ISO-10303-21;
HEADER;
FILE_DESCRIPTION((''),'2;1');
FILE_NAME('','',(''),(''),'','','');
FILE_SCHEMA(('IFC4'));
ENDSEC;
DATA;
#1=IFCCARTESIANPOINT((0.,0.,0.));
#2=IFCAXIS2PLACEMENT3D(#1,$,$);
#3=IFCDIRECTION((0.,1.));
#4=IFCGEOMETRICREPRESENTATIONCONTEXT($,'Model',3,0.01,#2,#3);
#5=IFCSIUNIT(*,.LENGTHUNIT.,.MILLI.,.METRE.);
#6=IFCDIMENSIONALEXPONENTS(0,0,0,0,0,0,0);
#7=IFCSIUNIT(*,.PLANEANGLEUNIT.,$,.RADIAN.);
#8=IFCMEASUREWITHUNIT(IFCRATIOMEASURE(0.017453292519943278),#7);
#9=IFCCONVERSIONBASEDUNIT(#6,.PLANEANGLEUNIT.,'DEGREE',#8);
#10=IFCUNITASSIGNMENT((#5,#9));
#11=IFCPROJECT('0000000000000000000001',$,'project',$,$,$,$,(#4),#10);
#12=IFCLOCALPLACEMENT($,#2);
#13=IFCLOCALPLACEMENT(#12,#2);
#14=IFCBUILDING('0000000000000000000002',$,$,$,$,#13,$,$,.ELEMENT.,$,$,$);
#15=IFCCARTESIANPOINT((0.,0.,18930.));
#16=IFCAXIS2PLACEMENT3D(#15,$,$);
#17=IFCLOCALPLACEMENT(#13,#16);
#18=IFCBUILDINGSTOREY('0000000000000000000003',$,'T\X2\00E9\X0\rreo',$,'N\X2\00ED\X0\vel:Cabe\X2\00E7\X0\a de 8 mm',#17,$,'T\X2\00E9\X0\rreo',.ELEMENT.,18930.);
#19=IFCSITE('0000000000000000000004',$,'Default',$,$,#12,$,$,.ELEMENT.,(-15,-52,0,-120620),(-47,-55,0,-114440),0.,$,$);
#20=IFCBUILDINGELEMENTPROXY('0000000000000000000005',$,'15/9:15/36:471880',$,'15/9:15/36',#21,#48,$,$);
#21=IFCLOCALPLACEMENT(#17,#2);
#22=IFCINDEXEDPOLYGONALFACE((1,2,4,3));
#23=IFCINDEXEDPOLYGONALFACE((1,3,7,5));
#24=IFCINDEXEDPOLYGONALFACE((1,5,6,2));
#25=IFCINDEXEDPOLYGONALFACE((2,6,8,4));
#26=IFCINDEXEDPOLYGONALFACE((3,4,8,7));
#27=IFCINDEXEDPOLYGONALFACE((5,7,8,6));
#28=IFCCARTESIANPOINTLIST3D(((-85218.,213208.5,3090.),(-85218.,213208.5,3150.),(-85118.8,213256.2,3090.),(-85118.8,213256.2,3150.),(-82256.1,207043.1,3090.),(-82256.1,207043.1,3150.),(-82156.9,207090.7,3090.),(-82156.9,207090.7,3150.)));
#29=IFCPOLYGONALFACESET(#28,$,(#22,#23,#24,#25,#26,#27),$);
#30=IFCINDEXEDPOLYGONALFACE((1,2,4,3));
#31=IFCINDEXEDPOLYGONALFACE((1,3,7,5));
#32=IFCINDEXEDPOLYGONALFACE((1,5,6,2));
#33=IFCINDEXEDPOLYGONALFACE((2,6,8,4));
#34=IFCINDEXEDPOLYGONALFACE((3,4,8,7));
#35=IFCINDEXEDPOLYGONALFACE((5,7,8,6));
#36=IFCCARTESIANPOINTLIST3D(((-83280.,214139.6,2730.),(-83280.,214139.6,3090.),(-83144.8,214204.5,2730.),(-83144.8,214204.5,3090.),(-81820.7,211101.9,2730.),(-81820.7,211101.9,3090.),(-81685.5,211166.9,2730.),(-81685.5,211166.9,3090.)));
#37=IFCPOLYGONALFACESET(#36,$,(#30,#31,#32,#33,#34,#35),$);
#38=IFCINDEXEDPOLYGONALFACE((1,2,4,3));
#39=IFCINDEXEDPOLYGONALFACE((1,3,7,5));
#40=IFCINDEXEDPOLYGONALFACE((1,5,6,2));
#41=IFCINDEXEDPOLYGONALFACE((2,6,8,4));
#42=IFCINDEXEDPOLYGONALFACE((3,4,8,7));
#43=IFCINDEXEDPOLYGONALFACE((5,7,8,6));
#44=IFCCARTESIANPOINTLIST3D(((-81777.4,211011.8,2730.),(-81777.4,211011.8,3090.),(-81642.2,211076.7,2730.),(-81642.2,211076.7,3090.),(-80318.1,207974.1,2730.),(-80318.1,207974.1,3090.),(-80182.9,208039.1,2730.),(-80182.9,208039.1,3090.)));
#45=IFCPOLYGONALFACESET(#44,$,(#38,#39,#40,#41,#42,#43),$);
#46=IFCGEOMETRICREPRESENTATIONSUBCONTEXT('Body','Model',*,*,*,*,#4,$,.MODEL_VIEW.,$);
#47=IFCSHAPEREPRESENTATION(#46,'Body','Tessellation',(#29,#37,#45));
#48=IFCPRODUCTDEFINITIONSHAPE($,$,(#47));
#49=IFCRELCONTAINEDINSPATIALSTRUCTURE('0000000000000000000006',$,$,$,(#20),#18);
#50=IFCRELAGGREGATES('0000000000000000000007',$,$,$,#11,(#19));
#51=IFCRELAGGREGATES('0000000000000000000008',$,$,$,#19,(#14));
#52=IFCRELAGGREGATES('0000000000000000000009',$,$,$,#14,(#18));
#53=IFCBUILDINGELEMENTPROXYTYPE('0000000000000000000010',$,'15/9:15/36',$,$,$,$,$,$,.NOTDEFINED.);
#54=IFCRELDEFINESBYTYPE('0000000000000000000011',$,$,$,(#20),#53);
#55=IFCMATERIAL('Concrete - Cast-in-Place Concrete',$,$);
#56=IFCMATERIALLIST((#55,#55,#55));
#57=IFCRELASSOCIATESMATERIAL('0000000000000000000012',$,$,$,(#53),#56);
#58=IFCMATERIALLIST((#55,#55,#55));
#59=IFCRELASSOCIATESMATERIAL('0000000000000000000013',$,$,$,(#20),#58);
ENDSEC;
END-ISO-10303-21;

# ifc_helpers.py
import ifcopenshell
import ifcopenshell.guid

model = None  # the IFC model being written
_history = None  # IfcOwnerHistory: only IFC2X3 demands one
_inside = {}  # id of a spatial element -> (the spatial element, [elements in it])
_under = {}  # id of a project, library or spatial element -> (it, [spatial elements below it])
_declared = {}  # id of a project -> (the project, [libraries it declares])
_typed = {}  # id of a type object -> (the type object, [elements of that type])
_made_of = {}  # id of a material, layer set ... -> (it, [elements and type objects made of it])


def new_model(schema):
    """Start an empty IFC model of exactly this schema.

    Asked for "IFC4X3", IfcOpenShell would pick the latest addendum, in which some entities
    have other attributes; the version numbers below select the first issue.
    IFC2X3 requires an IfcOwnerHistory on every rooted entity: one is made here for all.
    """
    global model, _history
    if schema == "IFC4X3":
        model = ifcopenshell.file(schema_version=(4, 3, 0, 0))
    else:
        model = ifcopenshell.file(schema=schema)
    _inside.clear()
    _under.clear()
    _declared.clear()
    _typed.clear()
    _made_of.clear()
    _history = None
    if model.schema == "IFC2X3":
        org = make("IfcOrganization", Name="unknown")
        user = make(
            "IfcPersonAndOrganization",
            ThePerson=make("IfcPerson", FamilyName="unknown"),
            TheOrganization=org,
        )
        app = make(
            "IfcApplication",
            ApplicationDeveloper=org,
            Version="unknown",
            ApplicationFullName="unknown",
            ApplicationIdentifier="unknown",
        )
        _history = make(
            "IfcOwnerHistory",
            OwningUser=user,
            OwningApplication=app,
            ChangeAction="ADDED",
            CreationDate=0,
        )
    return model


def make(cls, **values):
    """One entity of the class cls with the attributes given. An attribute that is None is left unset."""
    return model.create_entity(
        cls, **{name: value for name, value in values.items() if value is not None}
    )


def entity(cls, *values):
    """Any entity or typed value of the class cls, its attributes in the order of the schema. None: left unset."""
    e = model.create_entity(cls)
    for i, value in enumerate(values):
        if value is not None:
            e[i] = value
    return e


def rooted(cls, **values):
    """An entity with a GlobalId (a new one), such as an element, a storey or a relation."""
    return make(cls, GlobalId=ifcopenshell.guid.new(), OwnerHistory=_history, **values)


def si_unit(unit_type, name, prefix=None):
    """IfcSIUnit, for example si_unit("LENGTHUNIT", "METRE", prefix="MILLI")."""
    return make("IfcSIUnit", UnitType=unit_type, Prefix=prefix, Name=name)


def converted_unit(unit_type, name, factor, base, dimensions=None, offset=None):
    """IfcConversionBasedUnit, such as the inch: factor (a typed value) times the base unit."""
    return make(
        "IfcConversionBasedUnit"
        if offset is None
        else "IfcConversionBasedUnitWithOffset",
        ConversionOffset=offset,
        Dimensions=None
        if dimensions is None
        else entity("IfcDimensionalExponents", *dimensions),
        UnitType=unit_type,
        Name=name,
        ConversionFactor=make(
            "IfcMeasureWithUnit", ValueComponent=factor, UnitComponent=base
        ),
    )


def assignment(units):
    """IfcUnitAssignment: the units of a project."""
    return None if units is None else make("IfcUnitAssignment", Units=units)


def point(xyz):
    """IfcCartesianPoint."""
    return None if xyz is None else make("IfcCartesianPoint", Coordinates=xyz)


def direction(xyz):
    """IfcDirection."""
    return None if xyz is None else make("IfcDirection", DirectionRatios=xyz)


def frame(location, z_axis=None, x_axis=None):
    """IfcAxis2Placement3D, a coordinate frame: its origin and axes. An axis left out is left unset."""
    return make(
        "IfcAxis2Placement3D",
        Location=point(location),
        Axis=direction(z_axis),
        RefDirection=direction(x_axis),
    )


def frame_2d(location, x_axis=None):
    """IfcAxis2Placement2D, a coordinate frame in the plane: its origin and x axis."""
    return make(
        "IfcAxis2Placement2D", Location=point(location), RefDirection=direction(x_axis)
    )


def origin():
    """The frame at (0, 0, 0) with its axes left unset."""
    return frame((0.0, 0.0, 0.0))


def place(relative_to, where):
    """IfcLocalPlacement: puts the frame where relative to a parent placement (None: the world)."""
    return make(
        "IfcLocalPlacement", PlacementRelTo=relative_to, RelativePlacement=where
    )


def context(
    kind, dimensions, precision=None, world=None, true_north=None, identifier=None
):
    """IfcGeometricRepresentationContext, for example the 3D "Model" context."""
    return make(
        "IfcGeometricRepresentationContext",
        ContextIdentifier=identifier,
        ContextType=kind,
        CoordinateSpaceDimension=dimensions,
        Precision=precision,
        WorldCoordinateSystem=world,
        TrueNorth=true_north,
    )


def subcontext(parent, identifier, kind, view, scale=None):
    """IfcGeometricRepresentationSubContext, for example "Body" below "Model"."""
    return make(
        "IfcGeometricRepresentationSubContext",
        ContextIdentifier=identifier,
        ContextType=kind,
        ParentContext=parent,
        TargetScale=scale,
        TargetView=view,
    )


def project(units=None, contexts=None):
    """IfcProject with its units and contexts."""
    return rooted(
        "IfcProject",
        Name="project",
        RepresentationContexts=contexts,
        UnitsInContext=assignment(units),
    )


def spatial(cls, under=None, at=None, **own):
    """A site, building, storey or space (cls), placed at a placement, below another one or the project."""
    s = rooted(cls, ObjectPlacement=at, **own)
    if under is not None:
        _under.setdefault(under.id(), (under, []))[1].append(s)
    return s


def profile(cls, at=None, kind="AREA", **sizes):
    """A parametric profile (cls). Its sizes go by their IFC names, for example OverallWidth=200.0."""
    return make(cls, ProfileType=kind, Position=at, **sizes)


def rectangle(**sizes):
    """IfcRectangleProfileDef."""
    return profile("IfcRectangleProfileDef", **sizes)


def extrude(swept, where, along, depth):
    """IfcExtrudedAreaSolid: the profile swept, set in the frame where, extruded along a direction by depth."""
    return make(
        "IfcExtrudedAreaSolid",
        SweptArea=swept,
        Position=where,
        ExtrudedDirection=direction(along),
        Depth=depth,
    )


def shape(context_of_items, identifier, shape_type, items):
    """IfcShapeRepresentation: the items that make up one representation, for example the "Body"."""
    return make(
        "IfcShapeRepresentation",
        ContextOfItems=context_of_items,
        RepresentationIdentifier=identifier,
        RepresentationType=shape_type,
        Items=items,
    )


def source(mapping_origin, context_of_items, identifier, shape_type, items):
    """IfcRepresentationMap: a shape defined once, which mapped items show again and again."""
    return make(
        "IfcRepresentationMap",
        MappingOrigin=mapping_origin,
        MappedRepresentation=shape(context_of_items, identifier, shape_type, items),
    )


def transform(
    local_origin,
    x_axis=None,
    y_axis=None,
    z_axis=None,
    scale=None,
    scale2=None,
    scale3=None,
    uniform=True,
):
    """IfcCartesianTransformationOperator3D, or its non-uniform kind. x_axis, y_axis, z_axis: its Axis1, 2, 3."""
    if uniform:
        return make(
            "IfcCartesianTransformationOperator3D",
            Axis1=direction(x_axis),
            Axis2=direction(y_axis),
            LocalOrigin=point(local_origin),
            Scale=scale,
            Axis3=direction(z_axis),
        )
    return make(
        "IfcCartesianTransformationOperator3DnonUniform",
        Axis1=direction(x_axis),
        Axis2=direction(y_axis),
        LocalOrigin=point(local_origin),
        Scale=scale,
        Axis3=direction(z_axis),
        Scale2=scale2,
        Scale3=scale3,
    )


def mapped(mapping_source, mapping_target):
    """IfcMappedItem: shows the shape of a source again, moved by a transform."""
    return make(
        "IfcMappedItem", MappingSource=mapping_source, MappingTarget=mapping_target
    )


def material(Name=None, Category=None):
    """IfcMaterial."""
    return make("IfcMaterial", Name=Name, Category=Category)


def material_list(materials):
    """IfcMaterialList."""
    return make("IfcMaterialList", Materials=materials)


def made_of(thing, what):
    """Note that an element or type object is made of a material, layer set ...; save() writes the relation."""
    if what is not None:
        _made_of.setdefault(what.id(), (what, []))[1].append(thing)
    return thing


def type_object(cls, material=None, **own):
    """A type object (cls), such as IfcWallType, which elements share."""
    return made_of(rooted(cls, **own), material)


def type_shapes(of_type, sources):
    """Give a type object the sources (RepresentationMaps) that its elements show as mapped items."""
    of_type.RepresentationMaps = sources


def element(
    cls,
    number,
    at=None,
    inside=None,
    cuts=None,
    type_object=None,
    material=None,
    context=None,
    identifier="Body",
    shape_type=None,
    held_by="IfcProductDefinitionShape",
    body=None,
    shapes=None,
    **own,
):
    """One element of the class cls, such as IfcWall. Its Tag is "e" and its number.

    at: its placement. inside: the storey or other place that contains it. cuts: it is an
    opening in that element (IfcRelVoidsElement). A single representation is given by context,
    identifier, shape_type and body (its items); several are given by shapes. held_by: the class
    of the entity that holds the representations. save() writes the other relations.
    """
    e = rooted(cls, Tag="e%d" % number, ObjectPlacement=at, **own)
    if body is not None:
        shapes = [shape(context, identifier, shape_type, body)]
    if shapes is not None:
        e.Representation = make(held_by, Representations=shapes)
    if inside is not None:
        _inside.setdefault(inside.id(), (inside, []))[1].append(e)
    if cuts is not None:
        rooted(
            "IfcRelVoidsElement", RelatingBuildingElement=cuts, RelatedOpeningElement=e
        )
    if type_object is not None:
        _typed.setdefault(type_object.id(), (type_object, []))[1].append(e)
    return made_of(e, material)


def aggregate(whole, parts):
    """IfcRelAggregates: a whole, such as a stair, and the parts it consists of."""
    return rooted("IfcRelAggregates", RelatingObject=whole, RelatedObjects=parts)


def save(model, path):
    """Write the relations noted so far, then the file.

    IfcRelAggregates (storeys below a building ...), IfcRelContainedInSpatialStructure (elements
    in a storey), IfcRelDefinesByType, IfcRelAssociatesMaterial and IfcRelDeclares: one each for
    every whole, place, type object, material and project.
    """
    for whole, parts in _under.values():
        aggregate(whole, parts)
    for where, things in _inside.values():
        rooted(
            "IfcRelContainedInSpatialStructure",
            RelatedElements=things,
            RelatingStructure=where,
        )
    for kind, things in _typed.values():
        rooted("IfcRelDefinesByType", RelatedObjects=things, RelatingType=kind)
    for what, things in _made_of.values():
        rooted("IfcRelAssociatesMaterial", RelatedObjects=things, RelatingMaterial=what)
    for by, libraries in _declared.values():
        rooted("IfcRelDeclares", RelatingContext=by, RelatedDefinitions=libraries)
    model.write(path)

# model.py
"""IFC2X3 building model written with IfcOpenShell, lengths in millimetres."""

from ifc_helpers import new_model, entity, si_unit, converted_unit, direction, frame, frame_2d, origin, place, context, subcontext, project, spatial, rectangle, extrude, source, transform, mapped, material, material_list, type_object, type_shapes, element, save


model = new_model("IFC2X3")

# Units and contexts
model_context = context("Model", 3, precision=0.01, world=origin(), true_north=direction((0.0, 1.0)))
body_context = subcontext(model_context, "Body", "Model", "MODEL_VIEW")
ifc_project = project(units=[si_unit("LENGTHUNIT", "METRE", prefix="MILLI"), converted_unit("PLANEANGLEUNIT", "DEGREE", entity("IfcRatioMeasure", 0.017453292519943278), si_unit("PLANEANGLEUNIT", "RADIAN"), dimensions=[0, 0, 0, 0, 0, 0, 0])], contexts=[model_context])

# Site, building, storey
site_placement = place(None, origin())
site = spatial("IfcSite", under=ifc_project, at=site_placement, Name="Default", CompositionType="ELEMENT", RefLatitude=(-15, -52, 0, -120620), RefLongitude=(-47, -55, 0, -114440), RefElevation=0.0)
building_placement = place(site_placement, origin())
building = spatial("IfcBuilding", under=site, at=building_placement, CompositionType="ELEMENT")
storey_placement = place(building_placement, frame((0.0, 0.0, 18930.0)))
storey = spatial("IfcBuildingStorey", under=building, at=storey_placement, Name="Térreo", ObjectType="Nível:Cabeça de 8 mm", LongName="Térreo", CompositionType="ELEMENT", Elevation=18930.0)

# Building element proxy
ifc_material_1 = material(Name="Concrete - Cast-in-Place Concrete")
ifc_material_list_1 = material_list([ifc_material_1, ifc_material_1, ifc_material_1])
ifc_material_list_2 = material_list([ifc_material_1, ifc_material_1, ifc_material_1])
building_element_proxy_type_1 = type_object("IfcBuildingElementProxyType", Name="15/9:15/36", PredefinedType="NOTDEFINED", material=ifc_material_list_2)
shared_shape_1 = source(origin(), body_context, "Body", "SweptSolid", [
    extrude(rectangle(XDim=110.0, YDim=6840.0, at=frame_2d((0.0, 0.0), x_axis=(1.0, 0.0))), frame((1530.5, 3106.5, 360.0), z_axis=(0.0, 0.0, 1.0), x_axis=(0.90138, 0.43303, 0.0)), (0.0, 0.0, 1.0), 60.0),
    extrude(rectangle(XDim=3370.0, YDim=150.0, at=frame_2d((0.0, 0.0), x_axis=(1.0, 0.0))), frame((2735.2, 5610.1, 0.0), z_axis=(0.0, 0.0, 1.0), x_axis=(0.43303, -0.90138, 0.0)), (0.0, 0.0, 1.0), 360.0),
    extrude(rectangle(XDim=3370.0, YDim=150.0, at=frame_2d((0.0, 0.0), x_axis=(1.0, 0.0))), frame((4237.8, 2482.3, 0.0), z_axis=(0.0, 0.0, 1.0), x_axis=(0.43303, -0.90138, 0.0)), (0.0, 0.0, 1.0), 360.0),
])
type_shapes(building_element_proxy_type_1, [shared_shape_1])
proxy_1_placement = place(storey_placement, frame((-85218.0, 207043.1, 2730.0)))
element("IfcBuildingElementProxy", 1, at=proxy_1_placement, inside=storey, type_object=building_element_proxy_type_1, material=ifc_material_list_1, Name="15/9:15/36:471880", ObjectType="15/9:15/36", context=body_context, shape_type="MappedRepresentation", body=[
    mapped(shared_shape_1, transform((0.0, 0.0, 0.0), scale=1.0)),
])

save(model, "model.ifc")
